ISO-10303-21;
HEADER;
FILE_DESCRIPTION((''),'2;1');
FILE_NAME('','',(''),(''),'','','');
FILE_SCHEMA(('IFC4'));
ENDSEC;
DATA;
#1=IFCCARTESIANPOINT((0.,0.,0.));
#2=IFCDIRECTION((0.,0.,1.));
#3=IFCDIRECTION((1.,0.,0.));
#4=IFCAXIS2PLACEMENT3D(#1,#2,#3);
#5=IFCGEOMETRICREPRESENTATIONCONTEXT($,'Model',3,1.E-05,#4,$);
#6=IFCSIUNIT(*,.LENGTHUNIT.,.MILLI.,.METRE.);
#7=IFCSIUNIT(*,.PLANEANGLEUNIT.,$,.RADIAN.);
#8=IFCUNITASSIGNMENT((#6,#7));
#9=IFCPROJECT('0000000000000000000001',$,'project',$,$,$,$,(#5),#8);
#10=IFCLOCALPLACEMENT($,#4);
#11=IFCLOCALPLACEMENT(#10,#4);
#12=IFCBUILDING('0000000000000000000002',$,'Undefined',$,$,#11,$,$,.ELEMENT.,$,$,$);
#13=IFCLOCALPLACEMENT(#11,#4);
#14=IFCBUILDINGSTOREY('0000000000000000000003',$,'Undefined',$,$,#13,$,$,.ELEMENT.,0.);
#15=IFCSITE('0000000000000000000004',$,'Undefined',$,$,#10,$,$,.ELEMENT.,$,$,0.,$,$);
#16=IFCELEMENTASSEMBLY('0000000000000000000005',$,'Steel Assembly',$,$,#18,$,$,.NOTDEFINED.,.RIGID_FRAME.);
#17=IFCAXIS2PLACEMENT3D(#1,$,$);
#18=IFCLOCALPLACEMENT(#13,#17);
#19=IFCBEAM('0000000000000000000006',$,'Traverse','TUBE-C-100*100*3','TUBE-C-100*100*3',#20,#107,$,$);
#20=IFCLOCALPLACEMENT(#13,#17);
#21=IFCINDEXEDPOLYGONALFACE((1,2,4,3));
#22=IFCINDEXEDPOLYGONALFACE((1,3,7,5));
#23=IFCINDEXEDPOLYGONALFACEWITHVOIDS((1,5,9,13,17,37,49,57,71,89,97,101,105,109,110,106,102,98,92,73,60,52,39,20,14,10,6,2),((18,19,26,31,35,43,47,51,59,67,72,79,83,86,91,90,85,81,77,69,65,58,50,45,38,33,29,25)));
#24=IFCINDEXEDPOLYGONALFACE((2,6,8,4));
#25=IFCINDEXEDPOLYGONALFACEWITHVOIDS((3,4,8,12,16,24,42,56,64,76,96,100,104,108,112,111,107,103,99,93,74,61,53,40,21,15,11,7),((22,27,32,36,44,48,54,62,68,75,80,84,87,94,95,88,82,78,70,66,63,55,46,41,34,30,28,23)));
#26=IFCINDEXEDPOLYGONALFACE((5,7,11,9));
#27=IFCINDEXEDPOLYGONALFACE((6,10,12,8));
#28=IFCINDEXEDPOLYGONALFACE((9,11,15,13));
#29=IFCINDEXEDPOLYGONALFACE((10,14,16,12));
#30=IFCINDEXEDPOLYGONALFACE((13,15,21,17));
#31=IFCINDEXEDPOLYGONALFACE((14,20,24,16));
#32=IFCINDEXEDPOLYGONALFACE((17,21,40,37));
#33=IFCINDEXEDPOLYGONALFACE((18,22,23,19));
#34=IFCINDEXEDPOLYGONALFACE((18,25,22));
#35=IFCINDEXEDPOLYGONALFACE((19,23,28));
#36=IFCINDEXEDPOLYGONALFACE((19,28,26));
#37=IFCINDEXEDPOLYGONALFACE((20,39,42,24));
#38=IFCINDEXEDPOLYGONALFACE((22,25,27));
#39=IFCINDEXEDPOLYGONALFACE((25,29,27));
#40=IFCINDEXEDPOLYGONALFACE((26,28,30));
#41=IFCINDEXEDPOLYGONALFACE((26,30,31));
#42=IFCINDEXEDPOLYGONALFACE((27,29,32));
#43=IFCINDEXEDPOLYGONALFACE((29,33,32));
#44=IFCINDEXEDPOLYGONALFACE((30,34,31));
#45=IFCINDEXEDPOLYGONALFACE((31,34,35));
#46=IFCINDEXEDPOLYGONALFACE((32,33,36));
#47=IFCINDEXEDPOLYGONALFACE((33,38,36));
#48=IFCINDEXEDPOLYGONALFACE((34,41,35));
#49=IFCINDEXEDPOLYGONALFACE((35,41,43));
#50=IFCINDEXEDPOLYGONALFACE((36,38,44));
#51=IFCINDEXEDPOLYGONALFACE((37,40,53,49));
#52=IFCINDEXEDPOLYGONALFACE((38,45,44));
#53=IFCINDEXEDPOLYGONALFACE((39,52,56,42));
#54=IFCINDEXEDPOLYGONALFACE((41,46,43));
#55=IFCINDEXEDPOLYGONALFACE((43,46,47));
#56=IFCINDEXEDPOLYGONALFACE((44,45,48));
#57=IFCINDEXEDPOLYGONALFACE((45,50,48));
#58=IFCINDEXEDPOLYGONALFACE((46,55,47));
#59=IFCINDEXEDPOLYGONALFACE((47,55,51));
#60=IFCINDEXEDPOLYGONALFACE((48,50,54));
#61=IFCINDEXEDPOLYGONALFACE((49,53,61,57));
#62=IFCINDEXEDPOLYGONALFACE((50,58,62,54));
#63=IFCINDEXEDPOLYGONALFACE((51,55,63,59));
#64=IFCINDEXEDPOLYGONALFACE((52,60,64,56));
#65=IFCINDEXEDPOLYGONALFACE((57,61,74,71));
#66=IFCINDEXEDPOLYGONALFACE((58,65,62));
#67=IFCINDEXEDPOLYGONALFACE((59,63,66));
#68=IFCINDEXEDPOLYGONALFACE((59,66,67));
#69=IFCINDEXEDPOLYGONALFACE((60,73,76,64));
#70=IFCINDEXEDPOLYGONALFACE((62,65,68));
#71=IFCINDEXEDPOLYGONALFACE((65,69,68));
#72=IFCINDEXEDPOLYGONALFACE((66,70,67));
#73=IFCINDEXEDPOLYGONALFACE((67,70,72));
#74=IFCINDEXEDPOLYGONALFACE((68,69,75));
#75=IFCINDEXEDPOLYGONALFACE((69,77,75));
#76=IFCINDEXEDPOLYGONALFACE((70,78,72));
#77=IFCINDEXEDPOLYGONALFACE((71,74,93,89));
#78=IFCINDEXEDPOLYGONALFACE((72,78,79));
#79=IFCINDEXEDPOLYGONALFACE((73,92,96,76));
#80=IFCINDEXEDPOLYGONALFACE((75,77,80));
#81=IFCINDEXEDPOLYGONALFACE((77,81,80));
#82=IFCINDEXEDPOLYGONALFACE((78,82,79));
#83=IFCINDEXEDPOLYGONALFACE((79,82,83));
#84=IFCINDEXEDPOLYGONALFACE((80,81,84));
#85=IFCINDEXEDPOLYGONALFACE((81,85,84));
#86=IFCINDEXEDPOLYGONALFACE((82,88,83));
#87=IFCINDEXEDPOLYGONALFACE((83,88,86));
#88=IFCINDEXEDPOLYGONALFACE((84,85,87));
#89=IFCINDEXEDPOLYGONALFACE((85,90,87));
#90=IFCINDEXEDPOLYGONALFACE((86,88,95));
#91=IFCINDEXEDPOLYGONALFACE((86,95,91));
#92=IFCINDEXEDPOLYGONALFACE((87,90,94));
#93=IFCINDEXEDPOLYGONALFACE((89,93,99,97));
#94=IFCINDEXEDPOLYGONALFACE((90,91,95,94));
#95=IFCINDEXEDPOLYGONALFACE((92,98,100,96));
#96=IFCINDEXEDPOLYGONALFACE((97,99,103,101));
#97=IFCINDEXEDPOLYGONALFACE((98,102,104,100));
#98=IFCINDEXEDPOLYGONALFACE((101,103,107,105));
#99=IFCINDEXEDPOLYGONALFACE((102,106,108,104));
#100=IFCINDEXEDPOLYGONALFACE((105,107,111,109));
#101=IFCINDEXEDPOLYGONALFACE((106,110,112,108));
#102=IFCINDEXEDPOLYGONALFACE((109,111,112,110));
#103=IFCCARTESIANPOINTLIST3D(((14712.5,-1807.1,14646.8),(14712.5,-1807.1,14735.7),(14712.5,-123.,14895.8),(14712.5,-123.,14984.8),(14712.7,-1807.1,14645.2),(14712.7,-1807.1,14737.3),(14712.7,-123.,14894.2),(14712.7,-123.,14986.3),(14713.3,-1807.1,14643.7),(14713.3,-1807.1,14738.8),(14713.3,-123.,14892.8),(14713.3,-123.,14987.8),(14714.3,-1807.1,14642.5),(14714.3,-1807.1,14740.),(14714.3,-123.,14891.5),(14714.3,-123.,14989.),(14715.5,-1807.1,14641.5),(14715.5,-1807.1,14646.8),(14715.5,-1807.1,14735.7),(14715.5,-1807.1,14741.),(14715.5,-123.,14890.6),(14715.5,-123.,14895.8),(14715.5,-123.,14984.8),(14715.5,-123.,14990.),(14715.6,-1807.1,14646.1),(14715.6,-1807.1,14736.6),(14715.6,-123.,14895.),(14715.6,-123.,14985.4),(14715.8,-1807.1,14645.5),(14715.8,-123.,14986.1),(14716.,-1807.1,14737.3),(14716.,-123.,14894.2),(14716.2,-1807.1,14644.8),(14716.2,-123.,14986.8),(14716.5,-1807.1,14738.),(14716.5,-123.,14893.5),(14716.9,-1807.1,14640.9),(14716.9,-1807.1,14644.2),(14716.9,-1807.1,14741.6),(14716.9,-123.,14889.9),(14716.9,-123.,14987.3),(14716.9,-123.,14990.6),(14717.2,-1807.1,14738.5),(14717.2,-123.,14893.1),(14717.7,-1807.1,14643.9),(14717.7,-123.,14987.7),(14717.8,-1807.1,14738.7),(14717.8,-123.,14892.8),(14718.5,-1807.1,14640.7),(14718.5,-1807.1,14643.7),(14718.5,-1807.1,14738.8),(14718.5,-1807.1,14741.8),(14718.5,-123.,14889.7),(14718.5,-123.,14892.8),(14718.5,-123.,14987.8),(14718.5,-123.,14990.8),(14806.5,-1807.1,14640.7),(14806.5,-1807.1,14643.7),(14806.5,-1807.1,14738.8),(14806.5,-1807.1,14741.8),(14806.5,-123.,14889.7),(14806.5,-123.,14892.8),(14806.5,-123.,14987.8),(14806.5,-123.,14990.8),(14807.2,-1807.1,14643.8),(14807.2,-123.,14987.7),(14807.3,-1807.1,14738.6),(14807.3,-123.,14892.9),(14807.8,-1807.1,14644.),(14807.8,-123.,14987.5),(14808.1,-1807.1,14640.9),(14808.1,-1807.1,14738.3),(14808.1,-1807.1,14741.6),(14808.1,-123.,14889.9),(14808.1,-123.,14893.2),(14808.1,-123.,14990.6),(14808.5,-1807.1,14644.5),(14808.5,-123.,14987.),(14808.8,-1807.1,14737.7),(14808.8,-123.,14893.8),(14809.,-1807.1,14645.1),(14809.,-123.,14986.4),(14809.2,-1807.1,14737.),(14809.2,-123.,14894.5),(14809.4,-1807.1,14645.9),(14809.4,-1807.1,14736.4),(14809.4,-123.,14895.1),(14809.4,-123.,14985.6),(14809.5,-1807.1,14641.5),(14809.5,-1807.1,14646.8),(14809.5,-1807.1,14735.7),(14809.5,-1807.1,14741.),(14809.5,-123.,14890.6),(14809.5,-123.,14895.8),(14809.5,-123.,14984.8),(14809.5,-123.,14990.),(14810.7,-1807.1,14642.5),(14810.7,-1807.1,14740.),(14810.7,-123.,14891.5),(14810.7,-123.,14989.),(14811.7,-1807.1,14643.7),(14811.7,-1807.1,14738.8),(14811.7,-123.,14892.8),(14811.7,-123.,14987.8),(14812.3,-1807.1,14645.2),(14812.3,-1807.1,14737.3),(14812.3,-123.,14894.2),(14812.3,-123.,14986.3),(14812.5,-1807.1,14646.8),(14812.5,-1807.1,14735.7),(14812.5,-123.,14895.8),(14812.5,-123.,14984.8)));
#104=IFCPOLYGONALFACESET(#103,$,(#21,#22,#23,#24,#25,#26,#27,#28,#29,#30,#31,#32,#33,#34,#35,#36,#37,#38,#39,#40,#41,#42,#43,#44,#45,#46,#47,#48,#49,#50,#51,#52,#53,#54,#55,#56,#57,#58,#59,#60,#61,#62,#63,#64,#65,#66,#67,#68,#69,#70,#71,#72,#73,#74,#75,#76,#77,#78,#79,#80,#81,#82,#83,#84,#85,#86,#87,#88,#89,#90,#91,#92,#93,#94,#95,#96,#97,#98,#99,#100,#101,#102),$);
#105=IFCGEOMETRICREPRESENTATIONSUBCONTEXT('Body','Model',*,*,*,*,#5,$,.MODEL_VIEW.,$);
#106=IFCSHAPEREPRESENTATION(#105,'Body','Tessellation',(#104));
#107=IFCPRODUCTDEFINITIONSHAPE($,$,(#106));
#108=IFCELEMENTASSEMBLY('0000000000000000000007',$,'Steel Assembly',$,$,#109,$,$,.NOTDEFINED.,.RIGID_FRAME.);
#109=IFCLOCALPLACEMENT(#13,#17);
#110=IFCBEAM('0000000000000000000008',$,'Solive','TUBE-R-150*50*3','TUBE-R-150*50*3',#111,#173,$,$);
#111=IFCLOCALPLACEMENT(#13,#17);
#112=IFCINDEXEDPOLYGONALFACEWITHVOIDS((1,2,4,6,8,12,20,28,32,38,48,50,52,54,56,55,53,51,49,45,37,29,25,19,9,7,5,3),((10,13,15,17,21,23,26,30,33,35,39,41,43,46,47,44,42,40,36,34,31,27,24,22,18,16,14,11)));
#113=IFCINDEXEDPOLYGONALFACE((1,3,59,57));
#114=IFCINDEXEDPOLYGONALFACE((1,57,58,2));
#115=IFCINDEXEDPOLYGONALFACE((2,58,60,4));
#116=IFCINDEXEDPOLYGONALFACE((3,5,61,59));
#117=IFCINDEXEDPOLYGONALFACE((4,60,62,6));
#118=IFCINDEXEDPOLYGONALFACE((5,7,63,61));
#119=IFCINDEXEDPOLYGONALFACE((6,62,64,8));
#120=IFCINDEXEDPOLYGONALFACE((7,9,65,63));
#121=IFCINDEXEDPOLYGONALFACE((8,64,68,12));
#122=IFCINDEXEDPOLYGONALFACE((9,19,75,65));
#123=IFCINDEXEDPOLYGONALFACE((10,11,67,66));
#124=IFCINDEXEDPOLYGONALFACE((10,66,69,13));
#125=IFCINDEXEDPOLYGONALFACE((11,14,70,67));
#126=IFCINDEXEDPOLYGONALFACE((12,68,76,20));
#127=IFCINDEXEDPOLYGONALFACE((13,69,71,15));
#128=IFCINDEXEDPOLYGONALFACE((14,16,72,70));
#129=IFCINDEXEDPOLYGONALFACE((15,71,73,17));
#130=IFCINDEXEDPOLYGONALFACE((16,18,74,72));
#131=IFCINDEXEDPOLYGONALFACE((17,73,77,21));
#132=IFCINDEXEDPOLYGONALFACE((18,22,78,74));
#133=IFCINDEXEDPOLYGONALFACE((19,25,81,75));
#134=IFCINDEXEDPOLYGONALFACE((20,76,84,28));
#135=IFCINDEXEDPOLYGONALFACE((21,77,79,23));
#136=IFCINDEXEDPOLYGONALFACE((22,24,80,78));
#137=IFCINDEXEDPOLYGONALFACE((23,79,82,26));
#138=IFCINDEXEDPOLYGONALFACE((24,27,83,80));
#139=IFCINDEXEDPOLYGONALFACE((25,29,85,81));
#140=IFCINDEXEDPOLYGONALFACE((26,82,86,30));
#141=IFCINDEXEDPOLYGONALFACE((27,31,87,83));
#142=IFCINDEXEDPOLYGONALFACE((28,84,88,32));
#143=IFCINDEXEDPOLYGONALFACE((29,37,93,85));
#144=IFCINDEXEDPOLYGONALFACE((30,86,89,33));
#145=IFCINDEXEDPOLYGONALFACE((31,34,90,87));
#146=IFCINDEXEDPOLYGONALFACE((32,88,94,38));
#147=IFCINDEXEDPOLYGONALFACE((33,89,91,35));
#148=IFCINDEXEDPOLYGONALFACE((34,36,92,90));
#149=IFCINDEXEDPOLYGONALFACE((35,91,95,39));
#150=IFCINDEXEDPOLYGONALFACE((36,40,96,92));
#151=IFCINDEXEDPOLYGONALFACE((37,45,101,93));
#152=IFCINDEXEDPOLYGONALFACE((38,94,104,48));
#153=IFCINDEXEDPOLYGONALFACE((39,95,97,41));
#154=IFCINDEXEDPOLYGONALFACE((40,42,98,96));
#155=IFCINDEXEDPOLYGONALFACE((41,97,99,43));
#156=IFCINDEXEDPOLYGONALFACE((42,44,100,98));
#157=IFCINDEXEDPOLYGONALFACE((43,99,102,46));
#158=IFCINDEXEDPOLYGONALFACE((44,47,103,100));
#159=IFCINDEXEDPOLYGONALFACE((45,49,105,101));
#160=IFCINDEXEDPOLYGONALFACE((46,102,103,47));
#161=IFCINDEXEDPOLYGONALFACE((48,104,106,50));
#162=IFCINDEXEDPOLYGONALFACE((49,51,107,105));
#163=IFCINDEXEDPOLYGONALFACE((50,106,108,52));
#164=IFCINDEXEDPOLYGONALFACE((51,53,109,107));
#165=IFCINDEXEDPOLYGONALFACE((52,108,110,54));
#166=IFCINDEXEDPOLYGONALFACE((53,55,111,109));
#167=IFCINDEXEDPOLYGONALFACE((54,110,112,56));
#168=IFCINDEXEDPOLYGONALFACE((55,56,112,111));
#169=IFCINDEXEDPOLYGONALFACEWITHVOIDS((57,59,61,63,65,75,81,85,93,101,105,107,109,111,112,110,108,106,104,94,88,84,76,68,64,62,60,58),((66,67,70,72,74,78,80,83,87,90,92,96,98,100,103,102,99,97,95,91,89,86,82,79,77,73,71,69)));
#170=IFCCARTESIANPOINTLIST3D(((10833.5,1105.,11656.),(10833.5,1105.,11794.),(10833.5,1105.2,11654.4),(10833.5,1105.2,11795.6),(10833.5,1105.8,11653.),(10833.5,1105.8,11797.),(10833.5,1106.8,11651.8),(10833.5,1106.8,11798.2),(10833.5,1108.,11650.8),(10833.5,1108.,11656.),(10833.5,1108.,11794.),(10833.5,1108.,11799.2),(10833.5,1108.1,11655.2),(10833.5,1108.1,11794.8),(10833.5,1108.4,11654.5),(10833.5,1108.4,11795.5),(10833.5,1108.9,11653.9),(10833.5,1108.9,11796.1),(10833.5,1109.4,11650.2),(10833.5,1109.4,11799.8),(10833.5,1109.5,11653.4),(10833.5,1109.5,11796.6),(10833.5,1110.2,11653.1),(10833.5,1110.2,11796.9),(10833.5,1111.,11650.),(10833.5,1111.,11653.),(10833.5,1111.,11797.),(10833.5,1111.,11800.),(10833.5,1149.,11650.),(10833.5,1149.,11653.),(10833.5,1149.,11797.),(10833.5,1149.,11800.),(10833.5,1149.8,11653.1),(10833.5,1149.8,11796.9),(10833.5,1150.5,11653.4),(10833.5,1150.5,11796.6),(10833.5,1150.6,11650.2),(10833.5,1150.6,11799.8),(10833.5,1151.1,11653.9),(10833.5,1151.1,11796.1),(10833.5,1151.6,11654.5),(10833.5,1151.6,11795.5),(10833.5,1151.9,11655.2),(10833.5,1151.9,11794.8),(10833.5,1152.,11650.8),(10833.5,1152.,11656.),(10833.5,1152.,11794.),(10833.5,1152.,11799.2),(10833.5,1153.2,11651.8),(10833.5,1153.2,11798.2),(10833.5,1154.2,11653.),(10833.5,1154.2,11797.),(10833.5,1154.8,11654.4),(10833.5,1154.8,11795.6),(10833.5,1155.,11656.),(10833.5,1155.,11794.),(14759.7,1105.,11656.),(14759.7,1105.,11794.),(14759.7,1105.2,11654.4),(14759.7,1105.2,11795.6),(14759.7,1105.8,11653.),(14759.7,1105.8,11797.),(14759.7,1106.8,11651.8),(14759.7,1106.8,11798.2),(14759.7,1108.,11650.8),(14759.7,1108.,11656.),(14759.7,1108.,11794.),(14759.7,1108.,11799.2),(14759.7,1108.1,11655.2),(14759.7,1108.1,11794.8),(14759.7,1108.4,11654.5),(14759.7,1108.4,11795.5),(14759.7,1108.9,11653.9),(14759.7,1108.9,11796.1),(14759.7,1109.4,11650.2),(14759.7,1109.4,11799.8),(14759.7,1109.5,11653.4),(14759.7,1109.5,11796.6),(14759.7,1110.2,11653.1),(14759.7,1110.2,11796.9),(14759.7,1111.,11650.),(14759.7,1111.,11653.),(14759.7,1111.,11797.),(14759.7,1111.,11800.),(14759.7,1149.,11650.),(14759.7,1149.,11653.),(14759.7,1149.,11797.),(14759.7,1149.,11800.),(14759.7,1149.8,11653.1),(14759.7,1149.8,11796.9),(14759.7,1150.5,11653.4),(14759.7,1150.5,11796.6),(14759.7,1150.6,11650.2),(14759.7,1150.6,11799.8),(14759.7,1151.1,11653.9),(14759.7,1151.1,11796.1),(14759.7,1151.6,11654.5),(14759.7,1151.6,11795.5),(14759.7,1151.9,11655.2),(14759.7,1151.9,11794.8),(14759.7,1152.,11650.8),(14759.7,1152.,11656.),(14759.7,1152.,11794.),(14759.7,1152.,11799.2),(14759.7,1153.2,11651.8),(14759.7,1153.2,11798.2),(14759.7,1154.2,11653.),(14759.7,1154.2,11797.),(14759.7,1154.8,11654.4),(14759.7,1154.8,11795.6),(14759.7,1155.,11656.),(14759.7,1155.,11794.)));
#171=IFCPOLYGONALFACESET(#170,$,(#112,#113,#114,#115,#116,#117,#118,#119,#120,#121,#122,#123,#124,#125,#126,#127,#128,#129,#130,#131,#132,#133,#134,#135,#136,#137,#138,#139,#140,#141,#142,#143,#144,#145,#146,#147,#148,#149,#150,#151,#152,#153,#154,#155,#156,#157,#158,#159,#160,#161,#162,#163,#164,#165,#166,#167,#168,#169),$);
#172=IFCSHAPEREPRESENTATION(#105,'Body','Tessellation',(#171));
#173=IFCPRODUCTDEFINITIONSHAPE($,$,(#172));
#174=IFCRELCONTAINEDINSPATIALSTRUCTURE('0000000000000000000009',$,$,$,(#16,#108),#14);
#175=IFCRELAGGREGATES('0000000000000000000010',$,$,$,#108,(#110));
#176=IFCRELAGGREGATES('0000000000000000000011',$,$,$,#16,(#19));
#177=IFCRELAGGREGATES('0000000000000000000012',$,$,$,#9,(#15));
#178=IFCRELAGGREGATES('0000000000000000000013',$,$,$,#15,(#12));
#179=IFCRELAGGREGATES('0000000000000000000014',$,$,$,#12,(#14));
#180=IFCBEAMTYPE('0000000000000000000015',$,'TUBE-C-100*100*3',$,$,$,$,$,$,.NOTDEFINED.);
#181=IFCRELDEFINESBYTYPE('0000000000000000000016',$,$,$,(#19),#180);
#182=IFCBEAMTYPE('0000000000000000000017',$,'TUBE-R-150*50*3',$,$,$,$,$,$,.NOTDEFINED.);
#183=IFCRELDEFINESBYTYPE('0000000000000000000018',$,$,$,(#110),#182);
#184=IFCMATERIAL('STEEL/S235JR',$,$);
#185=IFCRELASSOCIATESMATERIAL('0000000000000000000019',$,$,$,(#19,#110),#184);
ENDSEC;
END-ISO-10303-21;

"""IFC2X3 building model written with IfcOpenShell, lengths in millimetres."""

from ifc_helpers import new_model, si_unit, frame, origin_with_axes, origin_2d_with_axis, place, context, subcontext, project, spatial, hollow_rectangle, extrude, clip, halfspace, material, type_object, element, aggregate, save


model = new_model("IFC2X3")

# Units and contexts
model_context = context("Model", 3, precision=1e-05, world=origin_with_axes())
body_context = subcontext(model_context, "Body", "Model", "MODEL_VIEW")
ifc_project = project(units=[si_unit("LENGTHUNIT", "METRE", prefix="MILLI"), si_unit("PLANEANGLEUNIT", "RADIAN")], contexts=[model_context])

# Site, building, storey
site_placement = place(None, origin_with_axes())
site = spatial("IfcSite", under=ifc_project, at=site_placement, Name="Undefined", CompositionType="ELEMENT", RefElevation=0.0)
building_placement = place(site_placement, origin_with_axes())
building = spatial("IfcBuilding", under=site, at=building_placement, Name="Undefined", CompositionType="ELEMENT")
storey_placement = place(building_placement, origin_with_axes())
storey = spatial("IfcBuildingStorey", under=building, at=storey_placement, Name="Undefined", CompositionType="ELEMENT", Elevation=0.0)

# Element assemblies, beams
ifc_material_1 = material(Name="STEEL/S235JR")
assembly_1_placement = place(storey_placement, origin_with_axes())
assembly_1 = element("IfcElementAssembly", 1, at=assembly_1_placement, inside=storey, Name="Steel Assembly", AssemblyPlace="NOTDEFINED", PredefinedType="RIGID_FRAME")
beam_type_1 = type_object("IfcBeamType", Name="TUBE-C-100*100*3", PredefinedType="NOTDEFINED")
beam_1_placement = place(assembly_1_placement, frame((14762.5, -1900.5, 14677.4), z_axis=(0.0, -0.146286, 0.989242), x_axis=(0.0, 0.989242, 0.146286)))
beam_1 = element("IfcBeam", 2, at=beam_1_placement, type_object=beam_type_1, material=ifc_material_1, Name="Traverse", Description="TUBE-C-100*100*3", ObjectType="TUBE-C-100*100*3", context=body_context, shape_type="Clipping", body=[
    clip(clip(extrude(hollow_rectangle(XDim=100.0, YDim=100.0, WallThickness=3.0, InnerFilletRadius=3.0, OuterFilletRadius=6.0, at=origin_2d_with_axis()), frame((1811.8, 0.0, 0.0), z_axis=(-1.0, 0.0, 0.0), x_axis=(0.0, -1.0, 0.0)), (0.0, 0.0, 1.0), 1732.3), halfspace(frame((1789.5, 0.0, -50.0), z_axis=(-0.989242, 0.0, 0.146286), x_axis=(0.0, 1.0, 0.0)), True)), halfspace(frame((91.1, 0.0, -22.5), z_axis=(0.989242, 0.0, -0.146286), x_axis=(0.146286, 0.0, 0.989242)), True)),
])
assembly_2_placement = place(storey_placement, origin_with_axes())
assembly_2 = element("IfcElementAssembly", 3, at=assembly_2_placement, inside=storey, Name="Steel Assembly", AssemblyPlace="NOTDEFINED", PredefinedType="RIGID_FRAME")
beam_type_2 = type_object("IfcBeamType", Name="TUBE-R-150*50*3", PredefinedType="NOTDEFINED")
beam_2_placement = place(assembly_2_placement, frame((14759.7, 1130.0, 11725.0), z_axis=(0.0, 0.0, 1.0), x_axis=(-1.0, 0.0, 0.0)))
beam_2 = element("IfcBeam", 4, at=beam_2_placement, type_object=beam_type_2, material=ifc_material_1, Name="Solive", Description="TUBE-R-150*50*3", ObjectType="TUBE-R-150*50*3", context=body_context, shape_type="SweptSolid", body=[
    extrude(hollow_rectangle(XDim=50.0, YDim=150.0, WallThickness=3.0, InnerFilletRadius=3.0, OuterFilletRadius=6.0, at=origin_2d_with_axis()), frame((3926.2, 0.0, 0.0), z_axis=(-1.0, 0.0, 0.0), x_axis=(0.0, -1.0, 0.0)), (0.0, 0.0, 1.0), 3926.2),
])
aggregate(assembly_2, [beam_2])

aggregate(assembly_1, [beam_1])

save(model, "model.ifc")
